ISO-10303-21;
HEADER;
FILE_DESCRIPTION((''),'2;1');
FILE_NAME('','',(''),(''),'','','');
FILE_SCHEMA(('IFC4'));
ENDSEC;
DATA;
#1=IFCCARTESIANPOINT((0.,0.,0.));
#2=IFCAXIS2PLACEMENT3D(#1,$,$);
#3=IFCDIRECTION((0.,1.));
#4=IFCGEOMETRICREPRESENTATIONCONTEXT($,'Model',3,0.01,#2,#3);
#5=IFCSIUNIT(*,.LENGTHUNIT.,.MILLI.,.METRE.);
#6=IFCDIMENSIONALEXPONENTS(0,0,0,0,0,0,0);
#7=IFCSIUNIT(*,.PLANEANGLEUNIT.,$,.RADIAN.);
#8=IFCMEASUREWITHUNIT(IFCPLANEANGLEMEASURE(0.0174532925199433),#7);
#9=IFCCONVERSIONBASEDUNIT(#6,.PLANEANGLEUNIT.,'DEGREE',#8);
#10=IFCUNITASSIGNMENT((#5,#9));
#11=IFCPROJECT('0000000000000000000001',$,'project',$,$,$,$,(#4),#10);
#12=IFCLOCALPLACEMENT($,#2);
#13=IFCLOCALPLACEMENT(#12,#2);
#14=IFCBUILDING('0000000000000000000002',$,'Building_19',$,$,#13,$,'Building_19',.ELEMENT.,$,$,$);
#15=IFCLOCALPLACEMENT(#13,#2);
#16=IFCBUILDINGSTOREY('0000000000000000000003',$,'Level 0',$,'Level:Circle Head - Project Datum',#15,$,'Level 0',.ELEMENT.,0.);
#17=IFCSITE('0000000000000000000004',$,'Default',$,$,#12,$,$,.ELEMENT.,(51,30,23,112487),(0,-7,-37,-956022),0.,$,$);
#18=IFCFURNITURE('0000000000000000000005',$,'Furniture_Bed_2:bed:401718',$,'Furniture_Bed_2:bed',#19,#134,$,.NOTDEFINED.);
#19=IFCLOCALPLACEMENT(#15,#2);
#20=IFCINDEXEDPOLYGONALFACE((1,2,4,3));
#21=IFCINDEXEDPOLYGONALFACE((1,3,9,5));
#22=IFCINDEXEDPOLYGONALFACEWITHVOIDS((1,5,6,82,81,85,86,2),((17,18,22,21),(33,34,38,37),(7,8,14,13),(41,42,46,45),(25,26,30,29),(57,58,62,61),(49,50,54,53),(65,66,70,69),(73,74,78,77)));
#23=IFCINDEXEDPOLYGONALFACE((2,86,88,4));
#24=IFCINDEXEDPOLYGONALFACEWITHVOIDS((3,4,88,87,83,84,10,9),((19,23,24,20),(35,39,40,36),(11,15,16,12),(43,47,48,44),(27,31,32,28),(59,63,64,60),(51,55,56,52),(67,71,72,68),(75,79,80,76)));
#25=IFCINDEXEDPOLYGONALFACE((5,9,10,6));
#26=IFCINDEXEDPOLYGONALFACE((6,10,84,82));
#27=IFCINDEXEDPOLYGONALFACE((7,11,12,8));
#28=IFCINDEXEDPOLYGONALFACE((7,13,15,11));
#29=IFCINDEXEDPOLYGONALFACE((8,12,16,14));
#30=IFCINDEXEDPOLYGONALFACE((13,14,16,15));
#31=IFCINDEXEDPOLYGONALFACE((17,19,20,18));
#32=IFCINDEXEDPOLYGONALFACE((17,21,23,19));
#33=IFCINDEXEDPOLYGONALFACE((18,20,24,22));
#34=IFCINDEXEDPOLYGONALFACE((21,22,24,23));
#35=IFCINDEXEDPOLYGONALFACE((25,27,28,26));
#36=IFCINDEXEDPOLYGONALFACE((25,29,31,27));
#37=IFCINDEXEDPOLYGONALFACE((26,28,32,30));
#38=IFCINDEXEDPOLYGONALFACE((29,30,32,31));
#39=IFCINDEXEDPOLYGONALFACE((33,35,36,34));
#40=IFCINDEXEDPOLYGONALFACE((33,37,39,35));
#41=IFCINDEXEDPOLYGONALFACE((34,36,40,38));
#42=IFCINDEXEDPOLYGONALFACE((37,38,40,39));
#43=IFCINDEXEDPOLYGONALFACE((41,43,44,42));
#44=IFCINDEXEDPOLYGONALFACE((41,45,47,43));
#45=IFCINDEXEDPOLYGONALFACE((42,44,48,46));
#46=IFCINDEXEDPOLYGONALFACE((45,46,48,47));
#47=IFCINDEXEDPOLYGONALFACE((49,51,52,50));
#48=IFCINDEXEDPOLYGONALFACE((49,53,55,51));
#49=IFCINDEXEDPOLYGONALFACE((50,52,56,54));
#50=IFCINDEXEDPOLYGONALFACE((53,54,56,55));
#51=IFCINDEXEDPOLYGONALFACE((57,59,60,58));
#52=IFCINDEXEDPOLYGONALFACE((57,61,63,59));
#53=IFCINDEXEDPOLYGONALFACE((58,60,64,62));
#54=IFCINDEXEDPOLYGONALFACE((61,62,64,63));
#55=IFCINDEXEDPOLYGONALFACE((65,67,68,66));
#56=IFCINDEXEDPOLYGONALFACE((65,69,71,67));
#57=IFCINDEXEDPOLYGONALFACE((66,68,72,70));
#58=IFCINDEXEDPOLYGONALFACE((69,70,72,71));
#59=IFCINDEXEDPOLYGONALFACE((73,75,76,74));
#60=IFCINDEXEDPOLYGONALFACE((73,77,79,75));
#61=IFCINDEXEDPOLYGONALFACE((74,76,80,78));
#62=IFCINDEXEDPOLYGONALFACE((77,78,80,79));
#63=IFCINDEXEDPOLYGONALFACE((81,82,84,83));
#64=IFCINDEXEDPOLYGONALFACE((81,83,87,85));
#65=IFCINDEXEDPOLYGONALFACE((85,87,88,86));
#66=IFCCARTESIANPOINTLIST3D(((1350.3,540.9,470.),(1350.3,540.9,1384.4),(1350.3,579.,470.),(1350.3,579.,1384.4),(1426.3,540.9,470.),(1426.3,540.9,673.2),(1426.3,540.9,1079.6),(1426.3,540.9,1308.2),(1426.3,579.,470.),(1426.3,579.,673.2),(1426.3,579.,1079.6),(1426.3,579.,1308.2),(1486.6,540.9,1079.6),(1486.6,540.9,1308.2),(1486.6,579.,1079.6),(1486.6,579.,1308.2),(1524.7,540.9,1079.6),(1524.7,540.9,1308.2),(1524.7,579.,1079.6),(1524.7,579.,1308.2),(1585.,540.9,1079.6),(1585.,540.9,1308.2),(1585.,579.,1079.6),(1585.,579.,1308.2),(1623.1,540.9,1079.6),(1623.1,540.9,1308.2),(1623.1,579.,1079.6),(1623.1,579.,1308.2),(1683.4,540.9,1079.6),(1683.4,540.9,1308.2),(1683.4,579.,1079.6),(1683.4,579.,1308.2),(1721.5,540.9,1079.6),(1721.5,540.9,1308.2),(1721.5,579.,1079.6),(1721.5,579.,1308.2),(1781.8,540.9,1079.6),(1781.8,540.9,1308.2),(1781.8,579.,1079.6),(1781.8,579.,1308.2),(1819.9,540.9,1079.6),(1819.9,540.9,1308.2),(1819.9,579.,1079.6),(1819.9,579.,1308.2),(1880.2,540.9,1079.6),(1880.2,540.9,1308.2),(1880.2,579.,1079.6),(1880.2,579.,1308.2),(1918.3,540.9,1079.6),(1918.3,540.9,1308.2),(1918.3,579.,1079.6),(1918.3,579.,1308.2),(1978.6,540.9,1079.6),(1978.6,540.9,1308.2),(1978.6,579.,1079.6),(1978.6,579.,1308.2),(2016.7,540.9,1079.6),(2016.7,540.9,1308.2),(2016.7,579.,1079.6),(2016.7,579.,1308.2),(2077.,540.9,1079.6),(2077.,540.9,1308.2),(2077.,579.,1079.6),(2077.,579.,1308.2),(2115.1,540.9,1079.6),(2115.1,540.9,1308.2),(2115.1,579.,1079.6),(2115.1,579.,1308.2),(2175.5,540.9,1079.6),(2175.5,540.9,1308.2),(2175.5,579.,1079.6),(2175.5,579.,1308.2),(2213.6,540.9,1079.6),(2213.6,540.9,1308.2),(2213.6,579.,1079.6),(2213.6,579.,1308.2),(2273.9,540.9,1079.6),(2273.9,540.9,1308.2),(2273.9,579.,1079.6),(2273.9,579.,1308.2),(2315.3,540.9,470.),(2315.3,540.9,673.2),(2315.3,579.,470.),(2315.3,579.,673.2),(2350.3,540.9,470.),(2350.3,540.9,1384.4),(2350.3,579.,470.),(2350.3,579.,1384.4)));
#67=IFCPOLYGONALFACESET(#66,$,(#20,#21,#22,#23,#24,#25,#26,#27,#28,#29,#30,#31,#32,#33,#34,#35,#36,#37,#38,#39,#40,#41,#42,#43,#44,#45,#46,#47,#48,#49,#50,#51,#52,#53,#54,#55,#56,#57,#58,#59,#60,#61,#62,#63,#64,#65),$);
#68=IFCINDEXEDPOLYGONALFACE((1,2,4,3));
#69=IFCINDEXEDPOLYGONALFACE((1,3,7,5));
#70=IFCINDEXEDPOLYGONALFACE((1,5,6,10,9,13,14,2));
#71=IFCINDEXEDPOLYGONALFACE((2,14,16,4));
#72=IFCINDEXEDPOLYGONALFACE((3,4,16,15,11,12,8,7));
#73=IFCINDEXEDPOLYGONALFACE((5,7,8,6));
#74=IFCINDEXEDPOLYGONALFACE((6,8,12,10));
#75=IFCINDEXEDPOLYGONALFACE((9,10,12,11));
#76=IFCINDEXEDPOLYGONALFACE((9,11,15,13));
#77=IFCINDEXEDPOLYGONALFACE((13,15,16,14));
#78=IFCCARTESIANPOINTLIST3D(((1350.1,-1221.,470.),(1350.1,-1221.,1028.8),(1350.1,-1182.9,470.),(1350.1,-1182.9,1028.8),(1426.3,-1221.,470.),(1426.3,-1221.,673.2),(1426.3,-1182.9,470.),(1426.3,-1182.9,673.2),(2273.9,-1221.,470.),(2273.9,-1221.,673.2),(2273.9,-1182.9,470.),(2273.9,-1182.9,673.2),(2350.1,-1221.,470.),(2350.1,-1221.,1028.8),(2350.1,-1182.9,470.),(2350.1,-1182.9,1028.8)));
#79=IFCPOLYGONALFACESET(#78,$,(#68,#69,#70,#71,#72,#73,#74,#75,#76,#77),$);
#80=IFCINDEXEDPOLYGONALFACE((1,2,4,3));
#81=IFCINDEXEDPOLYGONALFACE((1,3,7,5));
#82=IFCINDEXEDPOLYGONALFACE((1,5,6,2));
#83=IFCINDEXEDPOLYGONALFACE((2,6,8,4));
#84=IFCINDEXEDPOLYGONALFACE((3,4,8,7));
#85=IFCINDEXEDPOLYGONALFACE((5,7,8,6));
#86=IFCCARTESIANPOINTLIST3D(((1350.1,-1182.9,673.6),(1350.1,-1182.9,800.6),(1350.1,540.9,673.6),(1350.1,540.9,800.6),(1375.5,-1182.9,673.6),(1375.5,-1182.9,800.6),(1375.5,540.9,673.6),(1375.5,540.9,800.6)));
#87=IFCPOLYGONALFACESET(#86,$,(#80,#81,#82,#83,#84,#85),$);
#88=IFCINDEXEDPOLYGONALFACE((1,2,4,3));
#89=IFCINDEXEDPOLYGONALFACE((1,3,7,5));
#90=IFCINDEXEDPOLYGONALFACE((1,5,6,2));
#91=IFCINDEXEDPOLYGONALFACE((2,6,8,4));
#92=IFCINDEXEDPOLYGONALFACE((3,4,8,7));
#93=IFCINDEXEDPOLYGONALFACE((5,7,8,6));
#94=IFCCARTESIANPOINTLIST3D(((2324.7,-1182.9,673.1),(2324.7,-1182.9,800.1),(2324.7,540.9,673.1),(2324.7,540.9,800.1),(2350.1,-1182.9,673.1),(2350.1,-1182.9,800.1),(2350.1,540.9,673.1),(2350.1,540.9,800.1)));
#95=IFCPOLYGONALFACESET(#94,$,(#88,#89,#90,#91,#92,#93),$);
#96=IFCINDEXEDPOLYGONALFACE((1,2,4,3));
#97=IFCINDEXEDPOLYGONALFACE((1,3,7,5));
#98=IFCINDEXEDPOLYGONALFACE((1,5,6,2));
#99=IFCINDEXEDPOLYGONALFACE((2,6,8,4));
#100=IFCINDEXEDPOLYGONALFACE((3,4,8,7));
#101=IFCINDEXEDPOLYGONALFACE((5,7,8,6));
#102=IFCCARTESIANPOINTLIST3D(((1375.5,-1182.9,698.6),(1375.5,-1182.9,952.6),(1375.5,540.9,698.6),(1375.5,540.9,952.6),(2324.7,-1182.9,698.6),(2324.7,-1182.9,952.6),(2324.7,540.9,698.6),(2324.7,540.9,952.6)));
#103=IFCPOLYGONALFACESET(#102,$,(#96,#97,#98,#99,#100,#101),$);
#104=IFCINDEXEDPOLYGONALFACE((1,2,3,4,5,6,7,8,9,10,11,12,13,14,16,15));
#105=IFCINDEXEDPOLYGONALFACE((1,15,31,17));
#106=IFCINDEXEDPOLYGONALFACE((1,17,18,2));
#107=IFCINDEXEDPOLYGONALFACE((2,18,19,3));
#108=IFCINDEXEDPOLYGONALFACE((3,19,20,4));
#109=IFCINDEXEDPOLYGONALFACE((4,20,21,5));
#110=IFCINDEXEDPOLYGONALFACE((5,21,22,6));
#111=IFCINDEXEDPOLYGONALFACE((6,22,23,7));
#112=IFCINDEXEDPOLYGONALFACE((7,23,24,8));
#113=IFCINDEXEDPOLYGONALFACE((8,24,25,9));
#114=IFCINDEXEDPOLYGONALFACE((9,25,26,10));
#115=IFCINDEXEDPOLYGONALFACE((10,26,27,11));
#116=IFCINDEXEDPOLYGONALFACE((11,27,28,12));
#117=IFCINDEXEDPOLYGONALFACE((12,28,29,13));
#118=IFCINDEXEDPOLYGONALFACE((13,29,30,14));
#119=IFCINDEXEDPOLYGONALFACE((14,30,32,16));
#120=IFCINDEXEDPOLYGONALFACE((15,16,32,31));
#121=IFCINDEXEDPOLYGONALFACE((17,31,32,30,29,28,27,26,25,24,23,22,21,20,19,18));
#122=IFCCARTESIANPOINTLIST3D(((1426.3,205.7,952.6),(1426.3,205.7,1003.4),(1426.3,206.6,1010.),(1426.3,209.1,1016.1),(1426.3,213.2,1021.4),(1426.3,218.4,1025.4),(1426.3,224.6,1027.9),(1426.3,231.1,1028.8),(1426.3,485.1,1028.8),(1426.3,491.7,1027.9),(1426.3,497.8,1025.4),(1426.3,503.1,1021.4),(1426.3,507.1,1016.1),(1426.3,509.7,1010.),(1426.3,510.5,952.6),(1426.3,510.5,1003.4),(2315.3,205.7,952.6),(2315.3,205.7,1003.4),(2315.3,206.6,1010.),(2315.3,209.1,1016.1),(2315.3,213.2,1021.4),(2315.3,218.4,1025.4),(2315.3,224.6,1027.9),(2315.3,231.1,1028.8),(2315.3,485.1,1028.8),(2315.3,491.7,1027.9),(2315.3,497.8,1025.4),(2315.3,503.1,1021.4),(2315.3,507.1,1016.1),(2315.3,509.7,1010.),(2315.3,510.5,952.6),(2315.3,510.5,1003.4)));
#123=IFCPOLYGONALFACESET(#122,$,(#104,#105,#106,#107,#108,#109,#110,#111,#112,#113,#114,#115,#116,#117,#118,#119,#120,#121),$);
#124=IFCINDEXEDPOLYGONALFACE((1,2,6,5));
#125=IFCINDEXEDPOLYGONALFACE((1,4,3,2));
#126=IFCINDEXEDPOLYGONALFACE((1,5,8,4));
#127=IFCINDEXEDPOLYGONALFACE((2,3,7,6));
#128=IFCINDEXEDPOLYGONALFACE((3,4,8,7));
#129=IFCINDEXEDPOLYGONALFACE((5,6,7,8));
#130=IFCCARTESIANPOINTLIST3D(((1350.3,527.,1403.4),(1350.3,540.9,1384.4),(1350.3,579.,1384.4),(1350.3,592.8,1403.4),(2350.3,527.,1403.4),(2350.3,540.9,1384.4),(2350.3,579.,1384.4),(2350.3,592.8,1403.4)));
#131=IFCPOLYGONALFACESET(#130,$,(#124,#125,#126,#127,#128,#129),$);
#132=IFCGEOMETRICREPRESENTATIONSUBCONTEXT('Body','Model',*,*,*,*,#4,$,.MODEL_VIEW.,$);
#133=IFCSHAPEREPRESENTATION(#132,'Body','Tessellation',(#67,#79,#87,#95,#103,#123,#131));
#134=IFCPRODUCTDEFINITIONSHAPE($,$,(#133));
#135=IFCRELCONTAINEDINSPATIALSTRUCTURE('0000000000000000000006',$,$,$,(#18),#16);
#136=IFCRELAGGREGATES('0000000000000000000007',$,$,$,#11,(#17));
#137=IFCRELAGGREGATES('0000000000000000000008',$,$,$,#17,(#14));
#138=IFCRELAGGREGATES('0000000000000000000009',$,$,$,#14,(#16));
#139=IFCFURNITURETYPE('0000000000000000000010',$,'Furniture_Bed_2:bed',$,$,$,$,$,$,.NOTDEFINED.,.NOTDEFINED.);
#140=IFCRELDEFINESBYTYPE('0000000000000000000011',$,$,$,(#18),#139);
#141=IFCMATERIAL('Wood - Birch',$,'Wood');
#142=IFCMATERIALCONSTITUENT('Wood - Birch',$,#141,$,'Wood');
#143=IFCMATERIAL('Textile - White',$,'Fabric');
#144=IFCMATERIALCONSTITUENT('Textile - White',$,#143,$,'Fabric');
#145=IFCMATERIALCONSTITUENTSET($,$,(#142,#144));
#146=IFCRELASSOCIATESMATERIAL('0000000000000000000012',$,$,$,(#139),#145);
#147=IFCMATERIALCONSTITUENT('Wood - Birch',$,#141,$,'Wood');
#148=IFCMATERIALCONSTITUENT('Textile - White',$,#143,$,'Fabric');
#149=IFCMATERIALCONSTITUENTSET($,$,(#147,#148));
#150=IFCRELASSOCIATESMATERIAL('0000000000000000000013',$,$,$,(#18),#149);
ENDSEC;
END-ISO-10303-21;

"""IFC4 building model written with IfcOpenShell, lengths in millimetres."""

from ifc_helpers import new_model, entity, si_unit, converted_unit, direction, frame, origin, place, context, subcontext, project, spatial, line, arc, indexed_curve, outline, extrude, source, transform, mapped, material, constituent, constituent_set, type_object, type_shapes, element, save


model = new_model("IFC4")

# Units and contexts
model_context = context("Model", 3, precision=0.01, world=origin(), true_north=direction((0.0, 1.0)))
body_context = subcontext(model_context, "Body", "Model", "MODEL_VIEW")
ifc_project = project(units=[si_unit("LENGTHUNIT", "METRE", prefix="MILLI"), converted_unit("PLANEANGLEUNIT", "DEGREE", entity("IfcPlaneAngleMeasure", 0.0174532925199433), si_unit("PLANEANGLEUNIT", "RADIAN"), dimensions=[0, 0, 0, 0, 0, 0, 0])], contexts=[model_context])

# Site, building, storey
site_placement = place(None, origin())
site = spatial("IfcSite", under=ifc_project, at=site_placement, Name="Default", CompositionType="ELEMENT", RefLatitude=(51, 30, 23, 112487), RefLongitude=(0, -7, -37, -956022), RefElevation=0.0)
building_placement = place(site_placement, origin())
building = spatial("IfcBuilding", under=site, at=building_placement, Name="Building_19", LongName="Building_19", CompositionType="ELEMENT")
storey_placement = place(building_placement, origin())
storey = spatial("IfcBuildingStorey", under=building, at=storey_placement, Name="Level 0", ObjectType="Level:Circle Head - Project Datum", LongName="Level 0", CompositionType="ELEMENT", Elevation=0.0)

# Furniture
ifc_material_1 = material(Name="Wood - Birch", Category="Wood")
ifc_constituent_1 = constituent(ifc_material_1, Name="Wood - Birch", Category="Wood")
ifc_material_2 = material(Name="Textile - White", Category="Fabric")
ifc_constituent_2 = constituent(ifc_material_2, Name="Textile - White", Category="Fabric")
ifc_constituent_set_1 = constituent_set(constituents=[ifc_constituent_1, ifc_constituent_2])
ifc_constituent_3 = constituent(ifc_material_1, Name="Wood - Birch", Category="Wood")
ifc_constituent_4 = constituent(ifc_material_2, Name="Textile - White", Category="Fabric")
ifc_constituent_set_2 = constituent_set(constituents=[ifc_constituent_3, ifc_constituent_4])
furniture_type = type_object("IfcFurnitureType", Name="Furniture_Bed_2:bed", AssemblyPlace="NOTDEFINED", PredefinedType="NOTDEFINED", material=ifc_constituent_set_2)
shared_shape_1 = source(origin(), body_context, "Body", "SweptSolid", [
    extrude(outline(indexed_curve([(-635.0, -489.8), (279.4, -489.8), (279.4, -454.7), (76.2, -454.7), (76.2, 434.3), (279.4, 434.3), (279.4, 510.3), (-635.0, 510.3), (-635.0, -489.8)], self_intersect=False), holes=[indexed_curve([(-558.8, 374.0), (-558.8, 434.3), (-330.2, 434.3), (-330.2, 374.0), (-558.8, 374.0)], self_intersect=False), indexed_curve([(-558.8, 275.5), (-558.8, 335.9), (-330.2, 335.9), (-330.2, 275.5), (-558.8, 275.5)], self_intersect=False), indexed_curve([(-558.8, 177.1), (-558.8, 237.4), (-330.2, 237.4), (-330.2, 177.1), (-558.8, 177.1)], self_intersect=False), indexed_curve([(-558.8, 78.7), (-558.8, 139.0), (-330.2, 139.0), (-330.2, 78.7), (-558.8, 78.7)], self_intersect=False), indexed_curve([(-558.8, -118.1), (-558.8, -57.8), (-330.2, -57.8), (-330.2, -118.1), (-558.8, -118.1)], self_intersect=False), indexed_curve([(-558.8, -216.5), (-558.8, -156.2), (-330.2, -156.2), (-330.2, -216.5), (-558.8, -216.5)], self_intersect=False), indexed_curve([(-558.8, -314.9), (-558.8, -254.6), (-330.2, -254.6), (-330.2, -314.9), (-558.8, -314.9)], self_intersect=False), indexed_curve([(-558.8, -413.3), (-558.8, -353.0), (-330.2, -353.0), (-330.2, -413.3), (-558.8, -413.3)], self_intersect=False), indexed_curve([(-558.8, -19.7), (-558.8, 40.6), (-330.2, 40.6), (-330.2, -19.7), (-558.8, -19.7)], self_intersect=False)]), frame((-8.6, -38.1, 279.4), z_axis=(0.0, 1.0, 0.0), x_axis=(0.0, 0.0, -1.0)), (0.0, 0.0, 1.0), 38.1),
    extrude(outline(indexed_curve([(423.8, -190.5), (500.0, -190.5), (500.0, 368.3), (-500.0, 368.3), (-500.0, -190.5), (-423.8, -190.5), (-423.8, 12.7), (423.8, 12.7), (423.8, -190.5)], self_intersect=False)), frame((-19.1, -1800.0, 190.5), z_axis=(0.0, 1.0, 0.0), x_axis=(-1.0, 0.0, 0.0)), (0.0, 0.0, 1.0), 38.1),
    extrude(outline(indexed_curve([(-12.7, -861.9), (12.7, -861.9), (12.7, 861.9), (-12.7, 861.9), (-12.7, -861.9)], self_intersect=False)), frame((-506.4, -900.0, 203.6)), (0.0, 0.0, 1.0), 127.0),
    extrude(outline(indexed_curve([(-12.7, -861.9), (12.7, -861.9), (12.7, 861.9), (-12.7, 861.9), (-12.7, -861.9)], self_intersect=False)), frame((468.2, -900.0, 203.1)), (0.0, 0.0, 1.0), 127.0),
    extrude(outline(indexed_curve([(-474.6, -861.9), (474.6, -861.9), (474.6, 861.9), (-474.6, 861.9), (-474.6, -861.9)], self_intersect=False)), frame((-19.0, -900.0, 228.6), z_axis=(0.0, 0.0, 1.0), x_axis=(-1.0, 0.0, 0.0)), (0.0, 0.0, 1.0), 254.0),
    extrude(outline(indexed_curve([(-152.4, -42.3), (152.4, -42.3), (152.4, 8.5), (145.0, 26.4), (127.0, 33.9), (-127.0, 33.9), (-145.0, 26.4), (-152.4, 8.5)], segments=[line(1, 2, 3), arc(3, 4, 5), line(5, 6), arc(6, 7, 8), line(8, 1)], self_intersect=False)), frame((-442.9, -220.8, 524.9), z_axis=(1.0, 0.0, 0.0), x_axis=(0.0, 1.0, 0.0)), (0.0, 0.0, 1.0), 889.0),
    extrude(outline(indexed_curve([(-19.1, -9.5), (19.0, -9.5), (32.9, 9.5), (-32.9, 9.5), (-19.1, -9.5)], self_intersect=False)), frame((-518.8, -19.0, 923.9), z_axis=(1.0, 0.0, 0.0), x_axis=(0.0, 1.0, 0.0)), (0.0, 0.0, 1.0), 1000.1),
])
type_shapes(furniture_type, [shared_shape_1])
furniture_1_placement = place(storey_placement, frame((1869.1, 579.0, 470.0)))
element("IfcFurniture", 1, at=furniture_1_placement, inside=storey, type_object=furniture_type, material=ifc_constituent_set_1, Name="Furniture_Bed_2:bed:401718", ObjectType="Furniture_Bed_2:bed", PredefinedType="NOTDEFINED", context=body_context, shape_type="MappedRepresentation", body=[
    mapped(shared_shape_1, transform((0.0, 0.0, 0.0), scale=1.0)),
])

save(model, "model.ifc")
